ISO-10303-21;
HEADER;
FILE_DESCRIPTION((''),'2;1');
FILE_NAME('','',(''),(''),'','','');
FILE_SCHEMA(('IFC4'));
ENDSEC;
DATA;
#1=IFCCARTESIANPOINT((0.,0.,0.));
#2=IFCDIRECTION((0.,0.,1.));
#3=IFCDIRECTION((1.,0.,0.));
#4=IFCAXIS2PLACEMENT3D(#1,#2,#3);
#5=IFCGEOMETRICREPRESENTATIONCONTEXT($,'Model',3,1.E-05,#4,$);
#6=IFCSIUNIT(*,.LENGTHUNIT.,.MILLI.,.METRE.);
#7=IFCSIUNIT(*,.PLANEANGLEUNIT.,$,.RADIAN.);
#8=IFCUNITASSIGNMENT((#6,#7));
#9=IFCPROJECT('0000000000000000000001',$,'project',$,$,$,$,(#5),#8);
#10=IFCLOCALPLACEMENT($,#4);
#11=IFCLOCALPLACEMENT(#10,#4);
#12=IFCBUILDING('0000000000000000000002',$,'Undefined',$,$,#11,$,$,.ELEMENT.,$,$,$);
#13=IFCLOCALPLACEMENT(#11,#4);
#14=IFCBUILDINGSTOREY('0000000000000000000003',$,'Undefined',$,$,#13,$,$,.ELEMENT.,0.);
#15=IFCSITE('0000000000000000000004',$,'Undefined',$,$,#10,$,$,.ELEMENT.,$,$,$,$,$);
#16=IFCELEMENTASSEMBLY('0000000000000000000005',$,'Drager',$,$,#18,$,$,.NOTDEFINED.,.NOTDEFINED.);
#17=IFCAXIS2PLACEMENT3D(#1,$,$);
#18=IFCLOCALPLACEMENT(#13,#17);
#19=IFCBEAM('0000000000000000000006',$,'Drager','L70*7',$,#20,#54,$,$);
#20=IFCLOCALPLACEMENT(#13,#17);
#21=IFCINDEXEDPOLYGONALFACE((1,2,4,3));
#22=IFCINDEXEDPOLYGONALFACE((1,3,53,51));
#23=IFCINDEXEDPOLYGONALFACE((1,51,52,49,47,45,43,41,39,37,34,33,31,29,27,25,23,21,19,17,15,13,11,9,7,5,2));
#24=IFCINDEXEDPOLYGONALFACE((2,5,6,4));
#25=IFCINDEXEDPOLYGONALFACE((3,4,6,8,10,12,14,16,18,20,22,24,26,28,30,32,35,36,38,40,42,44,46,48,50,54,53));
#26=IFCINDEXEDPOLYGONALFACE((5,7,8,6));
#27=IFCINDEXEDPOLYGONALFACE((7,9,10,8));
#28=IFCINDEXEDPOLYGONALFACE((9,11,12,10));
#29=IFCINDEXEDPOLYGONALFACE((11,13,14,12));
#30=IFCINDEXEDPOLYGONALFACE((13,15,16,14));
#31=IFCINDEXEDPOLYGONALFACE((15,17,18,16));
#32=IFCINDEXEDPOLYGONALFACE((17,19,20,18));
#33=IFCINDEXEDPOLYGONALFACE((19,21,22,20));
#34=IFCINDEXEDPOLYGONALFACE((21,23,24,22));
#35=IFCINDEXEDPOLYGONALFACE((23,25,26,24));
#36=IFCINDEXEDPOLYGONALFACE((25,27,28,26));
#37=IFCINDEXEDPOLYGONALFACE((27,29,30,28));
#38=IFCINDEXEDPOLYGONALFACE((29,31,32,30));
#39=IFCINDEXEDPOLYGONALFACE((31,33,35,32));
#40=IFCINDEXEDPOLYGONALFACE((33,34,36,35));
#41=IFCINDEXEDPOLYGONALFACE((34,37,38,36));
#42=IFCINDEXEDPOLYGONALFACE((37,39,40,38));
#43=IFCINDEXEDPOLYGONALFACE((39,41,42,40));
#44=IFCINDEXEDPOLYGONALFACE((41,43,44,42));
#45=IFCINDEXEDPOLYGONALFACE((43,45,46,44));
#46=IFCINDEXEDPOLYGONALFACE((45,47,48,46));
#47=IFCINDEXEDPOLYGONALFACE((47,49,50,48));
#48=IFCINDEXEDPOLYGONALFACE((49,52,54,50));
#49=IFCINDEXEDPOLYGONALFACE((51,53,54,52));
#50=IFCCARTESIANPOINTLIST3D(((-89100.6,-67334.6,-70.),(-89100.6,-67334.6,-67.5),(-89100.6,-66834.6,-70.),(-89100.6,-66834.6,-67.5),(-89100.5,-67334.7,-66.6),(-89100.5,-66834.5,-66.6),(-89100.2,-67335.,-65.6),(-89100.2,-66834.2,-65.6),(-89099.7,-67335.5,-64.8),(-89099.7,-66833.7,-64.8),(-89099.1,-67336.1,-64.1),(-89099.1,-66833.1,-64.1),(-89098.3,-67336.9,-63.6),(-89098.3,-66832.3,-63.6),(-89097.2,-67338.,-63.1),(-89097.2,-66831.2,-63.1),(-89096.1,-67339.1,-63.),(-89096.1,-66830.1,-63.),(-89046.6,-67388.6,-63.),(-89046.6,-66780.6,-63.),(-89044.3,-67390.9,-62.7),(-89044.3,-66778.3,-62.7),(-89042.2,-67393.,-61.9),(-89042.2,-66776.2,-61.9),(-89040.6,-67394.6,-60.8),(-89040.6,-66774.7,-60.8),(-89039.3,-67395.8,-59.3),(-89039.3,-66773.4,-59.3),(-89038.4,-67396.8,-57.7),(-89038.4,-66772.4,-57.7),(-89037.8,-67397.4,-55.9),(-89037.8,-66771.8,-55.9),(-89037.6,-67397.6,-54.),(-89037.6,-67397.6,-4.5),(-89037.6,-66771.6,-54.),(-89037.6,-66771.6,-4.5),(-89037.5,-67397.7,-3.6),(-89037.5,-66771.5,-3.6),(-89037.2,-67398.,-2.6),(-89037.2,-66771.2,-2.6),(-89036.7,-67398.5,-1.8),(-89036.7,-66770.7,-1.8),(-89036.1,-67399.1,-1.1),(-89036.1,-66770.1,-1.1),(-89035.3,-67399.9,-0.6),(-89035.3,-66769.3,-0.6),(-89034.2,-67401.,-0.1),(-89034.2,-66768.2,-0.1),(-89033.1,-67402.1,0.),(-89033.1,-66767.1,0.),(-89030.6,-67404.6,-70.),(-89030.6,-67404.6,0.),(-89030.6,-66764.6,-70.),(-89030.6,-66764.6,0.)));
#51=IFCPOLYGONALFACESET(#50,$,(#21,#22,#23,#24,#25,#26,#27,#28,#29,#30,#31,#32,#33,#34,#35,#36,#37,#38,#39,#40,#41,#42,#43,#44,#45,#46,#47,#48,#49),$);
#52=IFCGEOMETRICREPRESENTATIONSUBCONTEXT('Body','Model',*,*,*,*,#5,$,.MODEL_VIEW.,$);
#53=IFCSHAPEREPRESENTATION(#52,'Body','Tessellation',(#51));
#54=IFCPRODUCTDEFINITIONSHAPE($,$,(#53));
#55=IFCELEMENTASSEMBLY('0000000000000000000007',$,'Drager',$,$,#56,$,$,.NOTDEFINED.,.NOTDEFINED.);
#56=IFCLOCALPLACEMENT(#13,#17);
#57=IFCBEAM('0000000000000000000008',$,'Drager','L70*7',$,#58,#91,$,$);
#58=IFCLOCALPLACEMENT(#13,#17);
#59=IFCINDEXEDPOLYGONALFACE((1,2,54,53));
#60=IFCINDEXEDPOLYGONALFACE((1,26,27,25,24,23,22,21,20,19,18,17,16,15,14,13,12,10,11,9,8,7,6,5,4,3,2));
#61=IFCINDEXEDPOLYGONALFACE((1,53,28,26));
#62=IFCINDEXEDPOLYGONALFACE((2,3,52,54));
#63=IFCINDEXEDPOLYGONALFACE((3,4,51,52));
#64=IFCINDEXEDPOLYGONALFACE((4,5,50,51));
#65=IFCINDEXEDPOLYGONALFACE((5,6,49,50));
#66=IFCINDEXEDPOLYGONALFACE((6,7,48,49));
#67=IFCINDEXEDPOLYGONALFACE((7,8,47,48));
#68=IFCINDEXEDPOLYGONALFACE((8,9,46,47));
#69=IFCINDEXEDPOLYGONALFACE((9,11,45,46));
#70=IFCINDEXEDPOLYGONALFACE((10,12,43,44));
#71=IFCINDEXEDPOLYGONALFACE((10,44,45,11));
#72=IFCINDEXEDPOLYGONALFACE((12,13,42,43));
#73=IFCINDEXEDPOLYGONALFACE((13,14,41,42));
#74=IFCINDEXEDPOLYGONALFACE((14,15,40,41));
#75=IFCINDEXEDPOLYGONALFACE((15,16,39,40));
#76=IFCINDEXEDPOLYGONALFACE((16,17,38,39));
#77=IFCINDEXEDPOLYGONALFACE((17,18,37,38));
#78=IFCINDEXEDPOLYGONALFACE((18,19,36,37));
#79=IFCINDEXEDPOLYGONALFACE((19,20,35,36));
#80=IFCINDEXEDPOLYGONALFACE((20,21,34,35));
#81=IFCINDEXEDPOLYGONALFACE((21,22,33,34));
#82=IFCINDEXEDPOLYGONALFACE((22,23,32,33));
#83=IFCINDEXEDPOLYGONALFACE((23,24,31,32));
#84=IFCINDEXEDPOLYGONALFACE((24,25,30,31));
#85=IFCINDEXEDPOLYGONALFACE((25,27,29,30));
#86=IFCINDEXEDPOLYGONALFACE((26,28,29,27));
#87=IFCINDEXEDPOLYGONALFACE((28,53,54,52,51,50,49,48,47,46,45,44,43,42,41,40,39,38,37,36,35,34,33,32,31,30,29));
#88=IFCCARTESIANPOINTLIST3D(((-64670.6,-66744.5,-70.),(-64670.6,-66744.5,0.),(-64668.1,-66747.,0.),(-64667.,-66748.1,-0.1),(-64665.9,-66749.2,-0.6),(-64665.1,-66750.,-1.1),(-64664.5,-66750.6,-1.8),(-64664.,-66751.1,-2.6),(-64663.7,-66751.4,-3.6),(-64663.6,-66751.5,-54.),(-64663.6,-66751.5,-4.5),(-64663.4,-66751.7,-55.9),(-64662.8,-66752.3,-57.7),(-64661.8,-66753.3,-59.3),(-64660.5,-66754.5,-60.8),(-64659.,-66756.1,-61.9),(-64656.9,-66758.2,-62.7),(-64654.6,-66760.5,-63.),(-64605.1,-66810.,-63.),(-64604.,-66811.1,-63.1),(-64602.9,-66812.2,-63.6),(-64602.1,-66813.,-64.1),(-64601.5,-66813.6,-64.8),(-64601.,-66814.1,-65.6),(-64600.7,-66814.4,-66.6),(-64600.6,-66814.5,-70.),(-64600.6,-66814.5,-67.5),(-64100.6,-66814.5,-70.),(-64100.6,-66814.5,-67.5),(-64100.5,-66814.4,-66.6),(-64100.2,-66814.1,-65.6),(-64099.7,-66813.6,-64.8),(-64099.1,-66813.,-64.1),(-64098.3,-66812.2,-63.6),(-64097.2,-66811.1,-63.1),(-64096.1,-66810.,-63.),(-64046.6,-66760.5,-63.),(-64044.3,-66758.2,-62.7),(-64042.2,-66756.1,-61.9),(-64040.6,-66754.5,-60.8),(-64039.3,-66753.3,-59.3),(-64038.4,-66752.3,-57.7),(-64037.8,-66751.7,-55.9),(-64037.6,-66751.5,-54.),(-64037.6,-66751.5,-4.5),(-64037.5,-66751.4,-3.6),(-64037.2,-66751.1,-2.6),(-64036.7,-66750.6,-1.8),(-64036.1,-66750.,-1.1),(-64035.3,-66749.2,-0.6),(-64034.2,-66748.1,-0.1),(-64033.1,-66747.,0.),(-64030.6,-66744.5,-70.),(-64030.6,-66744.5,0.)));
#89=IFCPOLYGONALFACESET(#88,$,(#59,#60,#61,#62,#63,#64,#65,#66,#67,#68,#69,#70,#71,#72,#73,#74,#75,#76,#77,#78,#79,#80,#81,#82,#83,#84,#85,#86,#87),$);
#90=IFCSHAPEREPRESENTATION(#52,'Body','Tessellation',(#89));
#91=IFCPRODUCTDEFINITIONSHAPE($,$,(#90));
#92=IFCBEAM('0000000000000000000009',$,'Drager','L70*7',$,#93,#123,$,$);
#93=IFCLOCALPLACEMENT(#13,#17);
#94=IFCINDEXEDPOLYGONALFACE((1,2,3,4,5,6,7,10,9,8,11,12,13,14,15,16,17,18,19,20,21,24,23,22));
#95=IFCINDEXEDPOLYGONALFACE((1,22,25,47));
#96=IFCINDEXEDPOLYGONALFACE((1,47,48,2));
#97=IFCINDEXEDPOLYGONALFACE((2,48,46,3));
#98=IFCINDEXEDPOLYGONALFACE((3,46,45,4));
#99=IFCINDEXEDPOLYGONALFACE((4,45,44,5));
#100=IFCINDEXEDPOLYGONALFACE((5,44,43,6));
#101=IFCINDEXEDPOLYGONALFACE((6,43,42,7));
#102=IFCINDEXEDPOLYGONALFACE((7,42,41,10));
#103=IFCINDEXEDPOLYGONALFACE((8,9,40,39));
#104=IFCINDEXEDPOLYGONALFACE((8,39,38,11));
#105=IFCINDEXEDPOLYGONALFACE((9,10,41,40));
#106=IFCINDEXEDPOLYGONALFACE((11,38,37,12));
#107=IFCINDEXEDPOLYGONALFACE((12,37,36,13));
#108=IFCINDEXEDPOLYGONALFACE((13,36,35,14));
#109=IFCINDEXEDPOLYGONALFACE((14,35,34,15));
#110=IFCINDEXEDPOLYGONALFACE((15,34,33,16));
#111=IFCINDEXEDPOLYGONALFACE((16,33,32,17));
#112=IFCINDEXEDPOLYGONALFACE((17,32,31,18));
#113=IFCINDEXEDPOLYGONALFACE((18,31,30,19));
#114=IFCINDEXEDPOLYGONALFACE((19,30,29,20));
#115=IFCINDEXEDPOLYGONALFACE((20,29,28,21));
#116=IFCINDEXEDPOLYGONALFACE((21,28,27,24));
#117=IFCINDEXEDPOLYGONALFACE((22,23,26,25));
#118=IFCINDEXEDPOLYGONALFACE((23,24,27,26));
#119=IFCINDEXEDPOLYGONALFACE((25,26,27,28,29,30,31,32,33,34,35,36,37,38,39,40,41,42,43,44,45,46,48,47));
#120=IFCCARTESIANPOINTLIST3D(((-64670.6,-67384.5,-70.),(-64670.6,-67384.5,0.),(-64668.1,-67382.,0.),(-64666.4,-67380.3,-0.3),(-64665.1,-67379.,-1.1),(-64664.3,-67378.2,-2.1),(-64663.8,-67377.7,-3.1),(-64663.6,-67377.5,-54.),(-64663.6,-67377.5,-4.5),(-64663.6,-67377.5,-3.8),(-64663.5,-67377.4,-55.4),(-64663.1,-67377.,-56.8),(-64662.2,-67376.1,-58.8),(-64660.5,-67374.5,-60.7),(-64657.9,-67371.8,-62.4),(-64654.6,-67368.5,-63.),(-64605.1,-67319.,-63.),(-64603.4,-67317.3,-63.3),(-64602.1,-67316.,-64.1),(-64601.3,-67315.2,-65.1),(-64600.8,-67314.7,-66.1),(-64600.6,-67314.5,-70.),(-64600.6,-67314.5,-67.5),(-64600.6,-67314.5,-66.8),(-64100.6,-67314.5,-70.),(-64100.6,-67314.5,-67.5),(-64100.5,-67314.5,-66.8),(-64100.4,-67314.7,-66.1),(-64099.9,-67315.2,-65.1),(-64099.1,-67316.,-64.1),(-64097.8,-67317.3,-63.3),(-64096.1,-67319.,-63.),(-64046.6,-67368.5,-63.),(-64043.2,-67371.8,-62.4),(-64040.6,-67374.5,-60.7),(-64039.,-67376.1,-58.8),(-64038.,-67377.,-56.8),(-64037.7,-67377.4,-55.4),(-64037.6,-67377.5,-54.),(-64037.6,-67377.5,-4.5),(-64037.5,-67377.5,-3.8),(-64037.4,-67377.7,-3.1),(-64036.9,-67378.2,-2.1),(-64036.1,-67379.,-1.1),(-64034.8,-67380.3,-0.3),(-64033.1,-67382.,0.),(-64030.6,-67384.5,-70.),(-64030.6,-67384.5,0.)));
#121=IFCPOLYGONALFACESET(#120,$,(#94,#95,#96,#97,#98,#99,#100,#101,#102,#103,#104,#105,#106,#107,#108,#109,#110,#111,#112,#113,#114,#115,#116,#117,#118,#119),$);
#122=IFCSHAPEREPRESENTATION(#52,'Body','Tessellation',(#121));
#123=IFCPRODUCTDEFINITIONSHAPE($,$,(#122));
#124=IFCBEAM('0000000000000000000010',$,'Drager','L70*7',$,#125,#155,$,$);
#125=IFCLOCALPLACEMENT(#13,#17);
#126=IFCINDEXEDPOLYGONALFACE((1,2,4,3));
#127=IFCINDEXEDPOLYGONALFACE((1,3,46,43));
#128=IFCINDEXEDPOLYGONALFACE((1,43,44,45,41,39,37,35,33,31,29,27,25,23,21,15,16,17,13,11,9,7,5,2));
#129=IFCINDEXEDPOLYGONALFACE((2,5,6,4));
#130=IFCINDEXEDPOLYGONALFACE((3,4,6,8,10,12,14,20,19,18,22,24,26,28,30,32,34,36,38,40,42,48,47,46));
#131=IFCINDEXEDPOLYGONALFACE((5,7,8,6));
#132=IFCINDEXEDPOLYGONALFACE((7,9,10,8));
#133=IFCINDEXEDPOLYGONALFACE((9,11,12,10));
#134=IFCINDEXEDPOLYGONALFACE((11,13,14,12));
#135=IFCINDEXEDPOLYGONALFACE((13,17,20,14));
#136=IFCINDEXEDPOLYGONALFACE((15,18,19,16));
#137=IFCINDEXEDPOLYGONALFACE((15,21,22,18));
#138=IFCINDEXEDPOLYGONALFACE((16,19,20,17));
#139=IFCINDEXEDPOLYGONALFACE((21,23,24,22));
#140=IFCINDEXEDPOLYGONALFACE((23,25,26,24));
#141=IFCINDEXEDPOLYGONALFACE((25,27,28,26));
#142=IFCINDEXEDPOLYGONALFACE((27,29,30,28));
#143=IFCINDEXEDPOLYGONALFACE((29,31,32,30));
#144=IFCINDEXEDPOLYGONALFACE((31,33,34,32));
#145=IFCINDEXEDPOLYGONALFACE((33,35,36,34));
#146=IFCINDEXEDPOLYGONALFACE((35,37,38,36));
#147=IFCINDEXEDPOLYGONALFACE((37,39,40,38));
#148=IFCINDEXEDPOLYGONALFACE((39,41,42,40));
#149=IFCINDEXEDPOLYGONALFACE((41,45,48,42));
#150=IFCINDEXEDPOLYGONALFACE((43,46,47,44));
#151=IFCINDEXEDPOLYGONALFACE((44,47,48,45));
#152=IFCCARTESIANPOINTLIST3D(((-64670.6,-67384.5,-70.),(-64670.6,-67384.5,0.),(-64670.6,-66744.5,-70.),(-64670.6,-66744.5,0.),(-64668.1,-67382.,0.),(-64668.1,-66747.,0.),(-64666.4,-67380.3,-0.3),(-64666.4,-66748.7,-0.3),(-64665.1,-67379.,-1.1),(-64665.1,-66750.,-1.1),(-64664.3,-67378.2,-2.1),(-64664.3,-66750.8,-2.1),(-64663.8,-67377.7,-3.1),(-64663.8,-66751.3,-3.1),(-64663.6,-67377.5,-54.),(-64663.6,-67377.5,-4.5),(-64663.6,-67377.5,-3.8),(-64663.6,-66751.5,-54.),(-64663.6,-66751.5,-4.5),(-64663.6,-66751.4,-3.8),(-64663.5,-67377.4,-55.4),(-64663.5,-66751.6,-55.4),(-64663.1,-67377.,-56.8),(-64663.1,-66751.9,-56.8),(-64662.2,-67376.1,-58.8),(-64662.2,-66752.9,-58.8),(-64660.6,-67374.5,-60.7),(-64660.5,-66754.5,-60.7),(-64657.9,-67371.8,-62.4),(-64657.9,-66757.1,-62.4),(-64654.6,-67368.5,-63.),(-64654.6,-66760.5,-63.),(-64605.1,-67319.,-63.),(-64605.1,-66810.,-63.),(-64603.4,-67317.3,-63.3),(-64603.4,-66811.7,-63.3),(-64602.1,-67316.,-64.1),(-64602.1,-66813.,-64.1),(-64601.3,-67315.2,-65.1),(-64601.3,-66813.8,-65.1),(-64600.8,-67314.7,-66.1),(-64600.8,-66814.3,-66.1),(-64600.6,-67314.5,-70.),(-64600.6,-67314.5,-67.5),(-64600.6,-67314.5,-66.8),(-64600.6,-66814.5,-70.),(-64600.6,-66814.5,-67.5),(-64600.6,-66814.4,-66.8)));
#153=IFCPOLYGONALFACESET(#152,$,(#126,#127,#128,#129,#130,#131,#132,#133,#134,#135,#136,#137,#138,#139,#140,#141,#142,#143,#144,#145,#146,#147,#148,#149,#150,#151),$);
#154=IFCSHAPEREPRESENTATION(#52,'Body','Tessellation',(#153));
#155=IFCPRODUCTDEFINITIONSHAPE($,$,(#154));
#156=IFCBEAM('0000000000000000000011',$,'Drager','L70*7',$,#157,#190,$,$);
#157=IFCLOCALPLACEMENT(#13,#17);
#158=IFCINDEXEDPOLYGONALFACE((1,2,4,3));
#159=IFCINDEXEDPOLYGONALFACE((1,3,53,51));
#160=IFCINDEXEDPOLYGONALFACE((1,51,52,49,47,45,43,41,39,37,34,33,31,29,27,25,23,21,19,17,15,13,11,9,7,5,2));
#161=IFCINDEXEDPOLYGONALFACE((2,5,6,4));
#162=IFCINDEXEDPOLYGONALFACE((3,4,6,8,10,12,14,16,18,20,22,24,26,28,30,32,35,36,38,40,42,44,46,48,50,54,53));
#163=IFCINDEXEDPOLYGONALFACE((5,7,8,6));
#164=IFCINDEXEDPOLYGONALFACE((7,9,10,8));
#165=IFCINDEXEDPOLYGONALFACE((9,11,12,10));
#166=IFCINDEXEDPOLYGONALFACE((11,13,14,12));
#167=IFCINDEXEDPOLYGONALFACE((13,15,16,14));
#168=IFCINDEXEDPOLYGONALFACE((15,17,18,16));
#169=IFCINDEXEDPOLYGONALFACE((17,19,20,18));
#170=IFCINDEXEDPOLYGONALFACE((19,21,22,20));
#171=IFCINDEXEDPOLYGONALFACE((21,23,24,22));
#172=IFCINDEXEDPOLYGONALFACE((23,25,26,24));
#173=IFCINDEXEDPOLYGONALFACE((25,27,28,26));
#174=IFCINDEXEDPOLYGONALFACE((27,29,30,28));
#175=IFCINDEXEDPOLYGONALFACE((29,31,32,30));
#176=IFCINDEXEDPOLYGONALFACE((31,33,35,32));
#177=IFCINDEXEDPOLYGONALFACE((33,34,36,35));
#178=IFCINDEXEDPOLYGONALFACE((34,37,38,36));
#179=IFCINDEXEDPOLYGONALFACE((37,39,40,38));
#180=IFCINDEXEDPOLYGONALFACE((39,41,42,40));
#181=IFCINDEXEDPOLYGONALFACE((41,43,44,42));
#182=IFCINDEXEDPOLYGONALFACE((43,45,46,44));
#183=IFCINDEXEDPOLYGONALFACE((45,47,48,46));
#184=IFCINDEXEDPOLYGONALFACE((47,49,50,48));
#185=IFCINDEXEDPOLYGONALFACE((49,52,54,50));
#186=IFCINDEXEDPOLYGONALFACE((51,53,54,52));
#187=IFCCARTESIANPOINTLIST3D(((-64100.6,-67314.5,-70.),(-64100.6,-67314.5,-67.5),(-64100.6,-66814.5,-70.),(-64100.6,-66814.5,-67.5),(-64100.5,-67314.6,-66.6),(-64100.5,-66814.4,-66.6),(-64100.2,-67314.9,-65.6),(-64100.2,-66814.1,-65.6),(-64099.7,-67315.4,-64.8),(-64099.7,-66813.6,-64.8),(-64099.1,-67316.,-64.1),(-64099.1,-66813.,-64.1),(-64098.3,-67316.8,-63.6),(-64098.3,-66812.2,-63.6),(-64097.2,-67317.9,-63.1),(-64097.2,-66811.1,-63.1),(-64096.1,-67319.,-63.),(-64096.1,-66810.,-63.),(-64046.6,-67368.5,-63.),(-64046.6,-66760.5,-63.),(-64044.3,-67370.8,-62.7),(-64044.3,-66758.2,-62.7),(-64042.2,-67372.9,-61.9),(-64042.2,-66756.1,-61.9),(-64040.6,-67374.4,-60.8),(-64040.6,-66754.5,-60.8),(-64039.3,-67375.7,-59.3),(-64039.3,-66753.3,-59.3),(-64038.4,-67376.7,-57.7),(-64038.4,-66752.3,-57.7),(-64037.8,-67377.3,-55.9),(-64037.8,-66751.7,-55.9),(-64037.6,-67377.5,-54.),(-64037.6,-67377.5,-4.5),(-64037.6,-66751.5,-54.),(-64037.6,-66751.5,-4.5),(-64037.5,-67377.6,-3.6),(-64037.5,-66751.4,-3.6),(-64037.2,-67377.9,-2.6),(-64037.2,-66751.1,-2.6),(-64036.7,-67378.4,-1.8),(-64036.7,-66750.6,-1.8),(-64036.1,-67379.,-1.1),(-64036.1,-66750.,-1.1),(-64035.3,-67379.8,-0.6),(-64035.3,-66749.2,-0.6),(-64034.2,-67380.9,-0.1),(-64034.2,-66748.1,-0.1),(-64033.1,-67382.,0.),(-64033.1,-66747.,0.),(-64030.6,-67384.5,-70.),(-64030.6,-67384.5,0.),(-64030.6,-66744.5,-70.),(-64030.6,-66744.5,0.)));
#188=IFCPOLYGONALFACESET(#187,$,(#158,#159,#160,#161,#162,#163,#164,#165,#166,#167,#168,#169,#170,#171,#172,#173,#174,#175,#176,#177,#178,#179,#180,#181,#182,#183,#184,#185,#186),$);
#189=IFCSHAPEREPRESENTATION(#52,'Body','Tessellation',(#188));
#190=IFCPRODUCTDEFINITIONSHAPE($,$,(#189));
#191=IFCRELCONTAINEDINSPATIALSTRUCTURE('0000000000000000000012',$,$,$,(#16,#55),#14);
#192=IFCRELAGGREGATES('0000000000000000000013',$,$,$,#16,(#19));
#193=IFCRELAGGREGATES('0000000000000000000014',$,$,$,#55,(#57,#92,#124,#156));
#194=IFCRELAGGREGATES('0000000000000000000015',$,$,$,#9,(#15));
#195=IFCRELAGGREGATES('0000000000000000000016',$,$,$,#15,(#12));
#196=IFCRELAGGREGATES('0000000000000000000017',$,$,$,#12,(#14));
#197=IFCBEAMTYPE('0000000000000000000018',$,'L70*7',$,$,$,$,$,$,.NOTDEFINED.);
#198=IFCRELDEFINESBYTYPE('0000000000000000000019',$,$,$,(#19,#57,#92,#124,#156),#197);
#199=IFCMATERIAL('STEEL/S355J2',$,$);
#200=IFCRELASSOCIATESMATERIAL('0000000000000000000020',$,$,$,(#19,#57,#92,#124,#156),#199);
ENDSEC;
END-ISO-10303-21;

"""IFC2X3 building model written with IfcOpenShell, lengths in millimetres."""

from ifc_helpers import new_model, si_unit, frame, origin_with_axes, origin_2d_with_axis, place, context, subcontext, project, spatial, l_section, extrude, clip, halfspace, material, type_object, element, aggregate, save


model = new_model("IFC2X3")

# Units and contexts
model_context = context("Model", 3, precision=1e-05, world=origin_with_axes())
body_context = subcontext(model_context, "Body", "Model", "MODEL_VIEW")
ifc_project = project(units=[si_unit("LENGTHUNIT", "METRE", prefix="MILLI"), si_unit("PLANEANGLEUNIT", "RADIAN")], contexts=[model_context])

# Site, building, storey
site_placement = place(None, origin_with_axes())
site = spatial("IfcSite", under=ifc_project, at=site_placement, Name="Undefined", CompositionType="ELEMENT")
building_placement = place(site_placement, origin_with_axes())
building = spatial("IfcBuilding", under=site, at=building_placement, Name="Undefined", CompositionType="ELEMENT")
storey_placement = place(building_placement, origin_with_axes())
storey = spatial("IfcBuildingStorey", under=building, at=storey_placement, Name="Undefined", CompositionType="ELEMENT", Elevation=0.0)

# Shared definitions
ifc_material_1 = material(Name="STEEL/S355J2")
beam_type_1 = type_object("IfcBeamType", Name="L70*7", PredefinedType="NOTDEFINED")

# Element assemblies, beams
assembly_1_placement = place(storey_placement, origin_with_axes())
assembly_1 = element("IfcElementAssembly", 1, at=assembly_1_placement, inside=storey, Name="Drager", AssemblyPlace="NOTDEFINED", PredefinedType="NOTDEFINED")
beam_1_placement = place(assembly_1_placement, frame((-89065.6, -66834.6, -35.0), z_axis=(0.0, 0.0, 1.0), x_axis=(0.000002, -1.0, 0.0)))
beam_1 = element("IfcBeam", 2, at=beam_1_placement, type_object=beam_type_1, material=ifc_material_1, Name="Drager", Description="L70*7", context=body_context, shape_type="Clipping", body=[
    clip(clip(extrude(l_section(Depth=70.0, Width=70.0, Thickness=7.0, FilletRadius=9.0, EdgeRadius=4.5, at=origin_2d_with_axis()), frame((605.7, 0.0, 0.0), z_axis=(-1.0, 0.0, 0.0), x_axis=(0.0, -1.0, 0.0)), (0.0, 0.0, 1.0), 711.4), halfspace(frame((500.0, -35.0, 35.0), z_axis=(-0.707107, 0.707107, 0.0), x_axis=(0.707107, 0.707107, 0.0)), True)), halfspace(frame((0.0, -35.0, 35.0), z_axis=(-0.707107, -0.707107, 0.0), x_axis=(-0.707107, 0.707107, 0.0)), False)),
])
aggregate(assembly_1, [beam_1])
assembly_2_placement = place(storey_placement, origin_with_axes())
assembly_2 = element("IfcElementAssembly", 3, at=assembly_2_placement, inside=storey, Name="Drager", AssemblyPlace="NOTDEFINED", PredefinedType="NOTDEFINED")
beam_2_placement = place(assembly_2_placement, frame((-64600.6, -66779.5, -35.0), z_axis=(0.0, 0.0, 1.0), x_axis=(1.0, 0.000003, 0.0)))
beam_2 = element("IfcBeam", 4, at=beam_2_placement, type_object=beam_type_1, material=ifc_material_1, Name="Drager", Description="L70*7", context=body_context, shape_type="Clipping", body=[
    clip(clip(extrude(l_section(Depth=70.0, Width=70.0, Thickness=7.0, FilletRadius=9.0, EdgeRadius=4.5, at=origin_2d_with_axis()), frame((605.7, 0.0, 0.0), z_axis=(-1.0, 0.0, 0.0), x_axis=(0.0, -1.0, 0.0)), (0.0, 0.0, 1.0), 711.4), halfspace(frame((500.0, -35.0, 35.0), z_axis=(-0.707107, 0.707107, 0.0), x_axis=(0.707107, 0.707107, 0.0)), True)), halfspace(frame((0.0, -35.0, 35.0), z_axis=(-0.707107, -0.707107, 0.0), x_axis=(-0.707107, 0.707107, 0.0)), False)),
])
beam_3_placement = place(assembly_2_placement, frame((-64100.6, -67349.5, -35.0), z_axis=(0.0, 0.0, 1.0), x_axis=(-1.0, 0.0, 0.0)))
beam_3 = element("IfcBeam", 5, at=beam_3_placement, type_object=beam_type_1, material=ifc_material_1, Name="Drager", Description="L70*7", context=body_context, shape_type="Clipping", body=[
    clip(clip(extrude(l_section(Depth=70.0, Width=70.0, Thickness=7.0, FilletRadius=9.0, EdgeRadius=4.5, at=origin_2d_with_axis()), frame((605.7, 0.0, 0.0), z_axis=(-1.0, 0.0, 0.0), x_axis=(0.0, -1.0, 0.0)), (0.0, 0.0, 1.0), 711.4), halfspace(frame((500.0, -35.0, 35.0), z_axis=(0.707107, -0.707107, 0.0), x_axis=(0.0, 0.0, 1.0)), False)), halfspace(frame((0.0, -35.0, 35.0), z_axis=(0.707107, 0.707107, 0.0), x_axis=(0.0, 0.0, 1.0)), True)),
])
beam_4_placement = place(assembly_2_placement, frame((-64635.6, -67314.5, -35.0), z_axis=(0.0, 0.0, 1.0), x_axis=(0.0, 1.0, 0.0)))
beam_4 = element("IfcBeam", 6, at=beam_4_placement, type_object=beam_type_1, material=ifc_material_1, Name="Drager", Description="L70*7", context=body_context, shape_type="Clipping", body=[
    clip(clip(extrude(l_section(Depth=70.0, Width=70.0, Thickness=7.0, FilletRadius=9.0, EdgeRadius=4.5, at=origin_2d_with_axis()), frame((605.7, 0.0, 0.0), z_axis=(-1.0, 0.0, 0.0), x_axis=(0.0, -1.0, 0.0)), (0.0, 0.0, 1.0), 711.4), halfspace(frame((500.0, -35.0, 35.0), z_axis=(0.707107, -0.707107, 0.0), x_axis=(0.0, 0.0, 1.0)), False)), halfspace(frame((0.0, -35.0, 35.0), z_axis=(0.707107, 0.707107, 0.0), x_axis=(0.0, 0.0, 1.0)), True)),
])
beam_5_placement = place(assembly_2_placement, frame((-64065.6, -66814.5, -35.0), z_axis=(0.0, 0.0, 1.0), x_axis=(0.000002, -1.0, 0.0)))
beam_5 = element("IfcBeam", 7, at=beam_5_placement, type_object=beam_type_1, material=ifc_material_1, Name="Drager", Description="L70*7", context=body_context, shape_type="Clipping", body=[
    clip(clip(extrude(l_section(Depth=70.0, Width=70.0, Thickness=7.0, FilletRadius=9.0, EdgeRadius=4.5, at=origin_2d_with_axis()), frame((605.7, 0.0, 0.0), z_axis=(-1.0, 0.0, 0.0), x_axis=(0.0, -1.0, 0.0)), (0.0, 0.0, 1.0), 711.4), halfspace(frame((500.0, -35.0, 35.0), z_axis=(-0.707107, 0.707107, 0.0), x_axis=(0.707107, 0.707107, 0.0)), True)), halfspace(frame((0.0, -35.0, 35.0), z_axis=(-0.707107, -0.707107, 0.0), x_axis=(-0.707107, 0.707107, 0.0)), False)),
])
aggregate(assembly_2, [beam_2, beam_3, beam_4, beam_5])

save(model, "model.ifc")
